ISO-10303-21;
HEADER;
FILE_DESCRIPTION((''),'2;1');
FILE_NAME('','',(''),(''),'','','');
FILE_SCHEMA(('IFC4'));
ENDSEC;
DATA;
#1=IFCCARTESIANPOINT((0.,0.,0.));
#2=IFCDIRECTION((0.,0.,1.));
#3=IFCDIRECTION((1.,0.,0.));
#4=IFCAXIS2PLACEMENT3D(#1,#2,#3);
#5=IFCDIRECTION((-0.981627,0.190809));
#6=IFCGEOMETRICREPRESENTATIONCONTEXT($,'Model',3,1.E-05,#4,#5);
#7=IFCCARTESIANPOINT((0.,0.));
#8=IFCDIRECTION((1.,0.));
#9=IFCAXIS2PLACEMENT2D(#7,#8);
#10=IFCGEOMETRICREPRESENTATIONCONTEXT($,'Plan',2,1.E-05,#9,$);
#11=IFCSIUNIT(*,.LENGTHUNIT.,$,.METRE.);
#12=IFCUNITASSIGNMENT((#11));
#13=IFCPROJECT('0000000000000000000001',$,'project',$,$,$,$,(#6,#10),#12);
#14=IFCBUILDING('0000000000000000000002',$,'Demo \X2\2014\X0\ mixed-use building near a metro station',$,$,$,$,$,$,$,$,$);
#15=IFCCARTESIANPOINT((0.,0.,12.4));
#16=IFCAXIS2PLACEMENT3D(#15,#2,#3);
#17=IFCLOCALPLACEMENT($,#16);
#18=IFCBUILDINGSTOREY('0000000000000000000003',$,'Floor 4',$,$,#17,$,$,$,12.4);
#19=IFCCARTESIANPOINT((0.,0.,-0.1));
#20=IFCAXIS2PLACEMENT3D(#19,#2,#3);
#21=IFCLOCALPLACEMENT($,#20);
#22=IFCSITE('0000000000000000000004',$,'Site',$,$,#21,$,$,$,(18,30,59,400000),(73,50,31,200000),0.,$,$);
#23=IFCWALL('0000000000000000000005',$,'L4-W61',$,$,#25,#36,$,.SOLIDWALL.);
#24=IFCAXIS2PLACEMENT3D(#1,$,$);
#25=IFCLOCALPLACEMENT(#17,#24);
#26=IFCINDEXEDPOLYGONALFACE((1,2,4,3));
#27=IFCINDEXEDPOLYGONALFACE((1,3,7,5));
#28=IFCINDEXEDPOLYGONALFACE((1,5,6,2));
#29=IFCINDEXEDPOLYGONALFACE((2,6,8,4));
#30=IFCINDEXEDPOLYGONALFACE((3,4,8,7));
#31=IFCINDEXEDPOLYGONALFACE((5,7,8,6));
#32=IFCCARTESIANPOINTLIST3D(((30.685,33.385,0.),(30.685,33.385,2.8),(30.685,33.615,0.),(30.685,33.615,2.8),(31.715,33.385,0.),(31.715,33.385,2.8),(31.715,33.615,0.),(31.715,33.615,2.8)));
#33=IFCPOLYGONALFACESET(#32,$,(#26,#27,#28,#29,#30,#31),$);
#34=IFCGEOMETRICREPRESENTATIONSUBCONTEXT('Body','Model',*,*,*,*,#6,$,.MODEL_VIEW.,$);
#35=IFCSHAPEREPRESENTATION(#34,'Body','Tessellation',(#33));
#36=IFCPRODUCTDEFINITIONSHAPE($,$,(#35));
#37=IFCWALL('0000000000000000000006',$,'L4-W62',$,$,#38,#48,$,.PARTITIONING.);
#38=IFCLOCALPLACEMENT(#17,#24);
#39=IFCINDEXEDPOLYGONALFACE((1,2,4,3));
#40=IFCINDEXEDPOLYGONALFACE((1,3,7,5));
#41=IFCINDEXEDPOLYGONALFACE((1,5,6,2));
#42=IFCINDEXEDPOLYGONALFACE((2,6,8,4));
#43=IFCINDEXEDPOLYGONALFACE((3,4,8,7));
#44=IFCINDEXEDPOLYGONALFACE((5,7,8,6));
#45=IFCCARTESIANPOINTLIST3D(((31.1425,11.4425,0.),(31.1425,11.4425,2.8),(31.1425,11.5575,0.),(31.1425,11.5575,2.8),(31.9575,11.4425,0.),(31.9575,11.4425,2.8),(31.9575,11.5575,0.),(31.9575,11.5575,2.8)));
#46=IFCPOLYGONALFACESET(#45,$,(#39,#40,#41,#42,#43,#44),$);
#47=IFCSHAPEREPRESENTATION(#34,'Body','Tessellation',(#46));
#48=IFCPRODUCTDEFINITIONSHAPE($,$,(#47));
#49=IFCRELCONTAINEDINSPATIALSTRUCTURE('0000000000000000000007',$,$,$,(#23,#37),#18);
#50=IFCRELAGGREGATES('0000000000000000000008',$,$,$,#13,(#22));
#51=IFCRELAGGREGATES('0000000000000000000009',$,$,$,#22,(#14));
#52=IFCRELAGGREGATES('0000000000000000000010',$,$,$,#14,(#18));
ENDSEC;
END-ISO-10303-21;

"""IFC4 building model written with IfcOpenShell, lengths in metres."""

from ifc_helpers import new_model, si_unit, direction, frame, origin_with_axes, origin_2d_with_axis, place, context, subcontext, project, spatial, line, indexed_curve, outline, extrude, element, save


model = new_model("IFC4")

# Units and contexts
model_context = context("Model", 3, precision=1e-05, world=origin_with_axes(), true_north=direction((-0.981627, 0.190809)))
plan_context = context("Plan", 2, precision=1e-05, world=origin_2d_with_axis())
body_context = subcontext(model_context, "Body", "Model", "MODEL_VIEW")
ifc_project = project(units=[si_unit("LENGTHUNIT", "METRE")], contexts=[model_context, plan_context])

# Site, building, storey
site_placement = place(None, frame((0.0, 0.0, -0.1), z_axis=(0.0, 0.0, 1.0), x_axis=(1.0, 0.0, 0.0)))
site = spatial("IfcSite", under=ifc_project, at=site_placement, Name="Site", RefLatitude=(18, 30, 59, 400000), RefLongitude=(73, 50, 31, 200000), RefElevation=0.0)
building = spatial("IfcBuilding", under=site, Name="Demo — mixed-use building near a metro station")
storey_placement = place(None, frame((0.0, 0.0, 12.4), z_axis=(0.0, 0.0, 1.0), x_axis=(1.0, 0.0, 0.0)))
storey = spatial("IfcBuildingStorey", under=building, at=storey_placement, Name="Floor 4", Elevation=12.4)

# Walls
wall_1_placement = place(storey_placement, frame((0.0, 0.0, -12.4), z_axis=(0.0, 0.0, 1.0), x_axis=(1.0, 0.0, 0.0)))
element("IfcWall", 1, at=wall_1_placement, inside=storey, Name="L4-W61", PredefinedType="SOLIDWALL", context=body_context, shape_type="SweptSolid", body=[
    extrude(outline(indexed_curve([(31.715, 33.385), (30.685, 33.385), (30.685, 33.615), (31.715, 33.615)], segments=[line(1, 2, 3, 4, 1)])), frame((0.0, 0.0, 12.4), z_axis=(0.0, 0.0, 1.0), x_axis=(1.0, 0.0, 0.0)), (0.0, 0.0, 1.0), 2.8),
])
wall_2_placement = place(storey_placement, frame((0.0, 0.0, -12.4), z_axis=(0.0, 0.0, 1.0), x_axis=(1.0, 0.0, 0.0)))
element("IfcWall", 2, at=wall_2_placement, inside=storey, Name="L4-W62", PredefinedType="PARTITIONING", context=body_context, shape_type="SweptSolid", body=[
    extrude(outline(indexed_curve([(31.1425, 11.5575), (31.9575, 11.5575), (31.9575, 11.4425), (31.1425, 11.4425)], segments=[line(1, 2, 3, 4, 1)])), frame((0.0, 0.0, 12.4), z_axis=(0.0, 0.0, 1.0), x_axis=(1.0, 0.0, 0.0)), (0.0, 0.0, 1.0), 2.8),
])

save(model, "model.ifc")
